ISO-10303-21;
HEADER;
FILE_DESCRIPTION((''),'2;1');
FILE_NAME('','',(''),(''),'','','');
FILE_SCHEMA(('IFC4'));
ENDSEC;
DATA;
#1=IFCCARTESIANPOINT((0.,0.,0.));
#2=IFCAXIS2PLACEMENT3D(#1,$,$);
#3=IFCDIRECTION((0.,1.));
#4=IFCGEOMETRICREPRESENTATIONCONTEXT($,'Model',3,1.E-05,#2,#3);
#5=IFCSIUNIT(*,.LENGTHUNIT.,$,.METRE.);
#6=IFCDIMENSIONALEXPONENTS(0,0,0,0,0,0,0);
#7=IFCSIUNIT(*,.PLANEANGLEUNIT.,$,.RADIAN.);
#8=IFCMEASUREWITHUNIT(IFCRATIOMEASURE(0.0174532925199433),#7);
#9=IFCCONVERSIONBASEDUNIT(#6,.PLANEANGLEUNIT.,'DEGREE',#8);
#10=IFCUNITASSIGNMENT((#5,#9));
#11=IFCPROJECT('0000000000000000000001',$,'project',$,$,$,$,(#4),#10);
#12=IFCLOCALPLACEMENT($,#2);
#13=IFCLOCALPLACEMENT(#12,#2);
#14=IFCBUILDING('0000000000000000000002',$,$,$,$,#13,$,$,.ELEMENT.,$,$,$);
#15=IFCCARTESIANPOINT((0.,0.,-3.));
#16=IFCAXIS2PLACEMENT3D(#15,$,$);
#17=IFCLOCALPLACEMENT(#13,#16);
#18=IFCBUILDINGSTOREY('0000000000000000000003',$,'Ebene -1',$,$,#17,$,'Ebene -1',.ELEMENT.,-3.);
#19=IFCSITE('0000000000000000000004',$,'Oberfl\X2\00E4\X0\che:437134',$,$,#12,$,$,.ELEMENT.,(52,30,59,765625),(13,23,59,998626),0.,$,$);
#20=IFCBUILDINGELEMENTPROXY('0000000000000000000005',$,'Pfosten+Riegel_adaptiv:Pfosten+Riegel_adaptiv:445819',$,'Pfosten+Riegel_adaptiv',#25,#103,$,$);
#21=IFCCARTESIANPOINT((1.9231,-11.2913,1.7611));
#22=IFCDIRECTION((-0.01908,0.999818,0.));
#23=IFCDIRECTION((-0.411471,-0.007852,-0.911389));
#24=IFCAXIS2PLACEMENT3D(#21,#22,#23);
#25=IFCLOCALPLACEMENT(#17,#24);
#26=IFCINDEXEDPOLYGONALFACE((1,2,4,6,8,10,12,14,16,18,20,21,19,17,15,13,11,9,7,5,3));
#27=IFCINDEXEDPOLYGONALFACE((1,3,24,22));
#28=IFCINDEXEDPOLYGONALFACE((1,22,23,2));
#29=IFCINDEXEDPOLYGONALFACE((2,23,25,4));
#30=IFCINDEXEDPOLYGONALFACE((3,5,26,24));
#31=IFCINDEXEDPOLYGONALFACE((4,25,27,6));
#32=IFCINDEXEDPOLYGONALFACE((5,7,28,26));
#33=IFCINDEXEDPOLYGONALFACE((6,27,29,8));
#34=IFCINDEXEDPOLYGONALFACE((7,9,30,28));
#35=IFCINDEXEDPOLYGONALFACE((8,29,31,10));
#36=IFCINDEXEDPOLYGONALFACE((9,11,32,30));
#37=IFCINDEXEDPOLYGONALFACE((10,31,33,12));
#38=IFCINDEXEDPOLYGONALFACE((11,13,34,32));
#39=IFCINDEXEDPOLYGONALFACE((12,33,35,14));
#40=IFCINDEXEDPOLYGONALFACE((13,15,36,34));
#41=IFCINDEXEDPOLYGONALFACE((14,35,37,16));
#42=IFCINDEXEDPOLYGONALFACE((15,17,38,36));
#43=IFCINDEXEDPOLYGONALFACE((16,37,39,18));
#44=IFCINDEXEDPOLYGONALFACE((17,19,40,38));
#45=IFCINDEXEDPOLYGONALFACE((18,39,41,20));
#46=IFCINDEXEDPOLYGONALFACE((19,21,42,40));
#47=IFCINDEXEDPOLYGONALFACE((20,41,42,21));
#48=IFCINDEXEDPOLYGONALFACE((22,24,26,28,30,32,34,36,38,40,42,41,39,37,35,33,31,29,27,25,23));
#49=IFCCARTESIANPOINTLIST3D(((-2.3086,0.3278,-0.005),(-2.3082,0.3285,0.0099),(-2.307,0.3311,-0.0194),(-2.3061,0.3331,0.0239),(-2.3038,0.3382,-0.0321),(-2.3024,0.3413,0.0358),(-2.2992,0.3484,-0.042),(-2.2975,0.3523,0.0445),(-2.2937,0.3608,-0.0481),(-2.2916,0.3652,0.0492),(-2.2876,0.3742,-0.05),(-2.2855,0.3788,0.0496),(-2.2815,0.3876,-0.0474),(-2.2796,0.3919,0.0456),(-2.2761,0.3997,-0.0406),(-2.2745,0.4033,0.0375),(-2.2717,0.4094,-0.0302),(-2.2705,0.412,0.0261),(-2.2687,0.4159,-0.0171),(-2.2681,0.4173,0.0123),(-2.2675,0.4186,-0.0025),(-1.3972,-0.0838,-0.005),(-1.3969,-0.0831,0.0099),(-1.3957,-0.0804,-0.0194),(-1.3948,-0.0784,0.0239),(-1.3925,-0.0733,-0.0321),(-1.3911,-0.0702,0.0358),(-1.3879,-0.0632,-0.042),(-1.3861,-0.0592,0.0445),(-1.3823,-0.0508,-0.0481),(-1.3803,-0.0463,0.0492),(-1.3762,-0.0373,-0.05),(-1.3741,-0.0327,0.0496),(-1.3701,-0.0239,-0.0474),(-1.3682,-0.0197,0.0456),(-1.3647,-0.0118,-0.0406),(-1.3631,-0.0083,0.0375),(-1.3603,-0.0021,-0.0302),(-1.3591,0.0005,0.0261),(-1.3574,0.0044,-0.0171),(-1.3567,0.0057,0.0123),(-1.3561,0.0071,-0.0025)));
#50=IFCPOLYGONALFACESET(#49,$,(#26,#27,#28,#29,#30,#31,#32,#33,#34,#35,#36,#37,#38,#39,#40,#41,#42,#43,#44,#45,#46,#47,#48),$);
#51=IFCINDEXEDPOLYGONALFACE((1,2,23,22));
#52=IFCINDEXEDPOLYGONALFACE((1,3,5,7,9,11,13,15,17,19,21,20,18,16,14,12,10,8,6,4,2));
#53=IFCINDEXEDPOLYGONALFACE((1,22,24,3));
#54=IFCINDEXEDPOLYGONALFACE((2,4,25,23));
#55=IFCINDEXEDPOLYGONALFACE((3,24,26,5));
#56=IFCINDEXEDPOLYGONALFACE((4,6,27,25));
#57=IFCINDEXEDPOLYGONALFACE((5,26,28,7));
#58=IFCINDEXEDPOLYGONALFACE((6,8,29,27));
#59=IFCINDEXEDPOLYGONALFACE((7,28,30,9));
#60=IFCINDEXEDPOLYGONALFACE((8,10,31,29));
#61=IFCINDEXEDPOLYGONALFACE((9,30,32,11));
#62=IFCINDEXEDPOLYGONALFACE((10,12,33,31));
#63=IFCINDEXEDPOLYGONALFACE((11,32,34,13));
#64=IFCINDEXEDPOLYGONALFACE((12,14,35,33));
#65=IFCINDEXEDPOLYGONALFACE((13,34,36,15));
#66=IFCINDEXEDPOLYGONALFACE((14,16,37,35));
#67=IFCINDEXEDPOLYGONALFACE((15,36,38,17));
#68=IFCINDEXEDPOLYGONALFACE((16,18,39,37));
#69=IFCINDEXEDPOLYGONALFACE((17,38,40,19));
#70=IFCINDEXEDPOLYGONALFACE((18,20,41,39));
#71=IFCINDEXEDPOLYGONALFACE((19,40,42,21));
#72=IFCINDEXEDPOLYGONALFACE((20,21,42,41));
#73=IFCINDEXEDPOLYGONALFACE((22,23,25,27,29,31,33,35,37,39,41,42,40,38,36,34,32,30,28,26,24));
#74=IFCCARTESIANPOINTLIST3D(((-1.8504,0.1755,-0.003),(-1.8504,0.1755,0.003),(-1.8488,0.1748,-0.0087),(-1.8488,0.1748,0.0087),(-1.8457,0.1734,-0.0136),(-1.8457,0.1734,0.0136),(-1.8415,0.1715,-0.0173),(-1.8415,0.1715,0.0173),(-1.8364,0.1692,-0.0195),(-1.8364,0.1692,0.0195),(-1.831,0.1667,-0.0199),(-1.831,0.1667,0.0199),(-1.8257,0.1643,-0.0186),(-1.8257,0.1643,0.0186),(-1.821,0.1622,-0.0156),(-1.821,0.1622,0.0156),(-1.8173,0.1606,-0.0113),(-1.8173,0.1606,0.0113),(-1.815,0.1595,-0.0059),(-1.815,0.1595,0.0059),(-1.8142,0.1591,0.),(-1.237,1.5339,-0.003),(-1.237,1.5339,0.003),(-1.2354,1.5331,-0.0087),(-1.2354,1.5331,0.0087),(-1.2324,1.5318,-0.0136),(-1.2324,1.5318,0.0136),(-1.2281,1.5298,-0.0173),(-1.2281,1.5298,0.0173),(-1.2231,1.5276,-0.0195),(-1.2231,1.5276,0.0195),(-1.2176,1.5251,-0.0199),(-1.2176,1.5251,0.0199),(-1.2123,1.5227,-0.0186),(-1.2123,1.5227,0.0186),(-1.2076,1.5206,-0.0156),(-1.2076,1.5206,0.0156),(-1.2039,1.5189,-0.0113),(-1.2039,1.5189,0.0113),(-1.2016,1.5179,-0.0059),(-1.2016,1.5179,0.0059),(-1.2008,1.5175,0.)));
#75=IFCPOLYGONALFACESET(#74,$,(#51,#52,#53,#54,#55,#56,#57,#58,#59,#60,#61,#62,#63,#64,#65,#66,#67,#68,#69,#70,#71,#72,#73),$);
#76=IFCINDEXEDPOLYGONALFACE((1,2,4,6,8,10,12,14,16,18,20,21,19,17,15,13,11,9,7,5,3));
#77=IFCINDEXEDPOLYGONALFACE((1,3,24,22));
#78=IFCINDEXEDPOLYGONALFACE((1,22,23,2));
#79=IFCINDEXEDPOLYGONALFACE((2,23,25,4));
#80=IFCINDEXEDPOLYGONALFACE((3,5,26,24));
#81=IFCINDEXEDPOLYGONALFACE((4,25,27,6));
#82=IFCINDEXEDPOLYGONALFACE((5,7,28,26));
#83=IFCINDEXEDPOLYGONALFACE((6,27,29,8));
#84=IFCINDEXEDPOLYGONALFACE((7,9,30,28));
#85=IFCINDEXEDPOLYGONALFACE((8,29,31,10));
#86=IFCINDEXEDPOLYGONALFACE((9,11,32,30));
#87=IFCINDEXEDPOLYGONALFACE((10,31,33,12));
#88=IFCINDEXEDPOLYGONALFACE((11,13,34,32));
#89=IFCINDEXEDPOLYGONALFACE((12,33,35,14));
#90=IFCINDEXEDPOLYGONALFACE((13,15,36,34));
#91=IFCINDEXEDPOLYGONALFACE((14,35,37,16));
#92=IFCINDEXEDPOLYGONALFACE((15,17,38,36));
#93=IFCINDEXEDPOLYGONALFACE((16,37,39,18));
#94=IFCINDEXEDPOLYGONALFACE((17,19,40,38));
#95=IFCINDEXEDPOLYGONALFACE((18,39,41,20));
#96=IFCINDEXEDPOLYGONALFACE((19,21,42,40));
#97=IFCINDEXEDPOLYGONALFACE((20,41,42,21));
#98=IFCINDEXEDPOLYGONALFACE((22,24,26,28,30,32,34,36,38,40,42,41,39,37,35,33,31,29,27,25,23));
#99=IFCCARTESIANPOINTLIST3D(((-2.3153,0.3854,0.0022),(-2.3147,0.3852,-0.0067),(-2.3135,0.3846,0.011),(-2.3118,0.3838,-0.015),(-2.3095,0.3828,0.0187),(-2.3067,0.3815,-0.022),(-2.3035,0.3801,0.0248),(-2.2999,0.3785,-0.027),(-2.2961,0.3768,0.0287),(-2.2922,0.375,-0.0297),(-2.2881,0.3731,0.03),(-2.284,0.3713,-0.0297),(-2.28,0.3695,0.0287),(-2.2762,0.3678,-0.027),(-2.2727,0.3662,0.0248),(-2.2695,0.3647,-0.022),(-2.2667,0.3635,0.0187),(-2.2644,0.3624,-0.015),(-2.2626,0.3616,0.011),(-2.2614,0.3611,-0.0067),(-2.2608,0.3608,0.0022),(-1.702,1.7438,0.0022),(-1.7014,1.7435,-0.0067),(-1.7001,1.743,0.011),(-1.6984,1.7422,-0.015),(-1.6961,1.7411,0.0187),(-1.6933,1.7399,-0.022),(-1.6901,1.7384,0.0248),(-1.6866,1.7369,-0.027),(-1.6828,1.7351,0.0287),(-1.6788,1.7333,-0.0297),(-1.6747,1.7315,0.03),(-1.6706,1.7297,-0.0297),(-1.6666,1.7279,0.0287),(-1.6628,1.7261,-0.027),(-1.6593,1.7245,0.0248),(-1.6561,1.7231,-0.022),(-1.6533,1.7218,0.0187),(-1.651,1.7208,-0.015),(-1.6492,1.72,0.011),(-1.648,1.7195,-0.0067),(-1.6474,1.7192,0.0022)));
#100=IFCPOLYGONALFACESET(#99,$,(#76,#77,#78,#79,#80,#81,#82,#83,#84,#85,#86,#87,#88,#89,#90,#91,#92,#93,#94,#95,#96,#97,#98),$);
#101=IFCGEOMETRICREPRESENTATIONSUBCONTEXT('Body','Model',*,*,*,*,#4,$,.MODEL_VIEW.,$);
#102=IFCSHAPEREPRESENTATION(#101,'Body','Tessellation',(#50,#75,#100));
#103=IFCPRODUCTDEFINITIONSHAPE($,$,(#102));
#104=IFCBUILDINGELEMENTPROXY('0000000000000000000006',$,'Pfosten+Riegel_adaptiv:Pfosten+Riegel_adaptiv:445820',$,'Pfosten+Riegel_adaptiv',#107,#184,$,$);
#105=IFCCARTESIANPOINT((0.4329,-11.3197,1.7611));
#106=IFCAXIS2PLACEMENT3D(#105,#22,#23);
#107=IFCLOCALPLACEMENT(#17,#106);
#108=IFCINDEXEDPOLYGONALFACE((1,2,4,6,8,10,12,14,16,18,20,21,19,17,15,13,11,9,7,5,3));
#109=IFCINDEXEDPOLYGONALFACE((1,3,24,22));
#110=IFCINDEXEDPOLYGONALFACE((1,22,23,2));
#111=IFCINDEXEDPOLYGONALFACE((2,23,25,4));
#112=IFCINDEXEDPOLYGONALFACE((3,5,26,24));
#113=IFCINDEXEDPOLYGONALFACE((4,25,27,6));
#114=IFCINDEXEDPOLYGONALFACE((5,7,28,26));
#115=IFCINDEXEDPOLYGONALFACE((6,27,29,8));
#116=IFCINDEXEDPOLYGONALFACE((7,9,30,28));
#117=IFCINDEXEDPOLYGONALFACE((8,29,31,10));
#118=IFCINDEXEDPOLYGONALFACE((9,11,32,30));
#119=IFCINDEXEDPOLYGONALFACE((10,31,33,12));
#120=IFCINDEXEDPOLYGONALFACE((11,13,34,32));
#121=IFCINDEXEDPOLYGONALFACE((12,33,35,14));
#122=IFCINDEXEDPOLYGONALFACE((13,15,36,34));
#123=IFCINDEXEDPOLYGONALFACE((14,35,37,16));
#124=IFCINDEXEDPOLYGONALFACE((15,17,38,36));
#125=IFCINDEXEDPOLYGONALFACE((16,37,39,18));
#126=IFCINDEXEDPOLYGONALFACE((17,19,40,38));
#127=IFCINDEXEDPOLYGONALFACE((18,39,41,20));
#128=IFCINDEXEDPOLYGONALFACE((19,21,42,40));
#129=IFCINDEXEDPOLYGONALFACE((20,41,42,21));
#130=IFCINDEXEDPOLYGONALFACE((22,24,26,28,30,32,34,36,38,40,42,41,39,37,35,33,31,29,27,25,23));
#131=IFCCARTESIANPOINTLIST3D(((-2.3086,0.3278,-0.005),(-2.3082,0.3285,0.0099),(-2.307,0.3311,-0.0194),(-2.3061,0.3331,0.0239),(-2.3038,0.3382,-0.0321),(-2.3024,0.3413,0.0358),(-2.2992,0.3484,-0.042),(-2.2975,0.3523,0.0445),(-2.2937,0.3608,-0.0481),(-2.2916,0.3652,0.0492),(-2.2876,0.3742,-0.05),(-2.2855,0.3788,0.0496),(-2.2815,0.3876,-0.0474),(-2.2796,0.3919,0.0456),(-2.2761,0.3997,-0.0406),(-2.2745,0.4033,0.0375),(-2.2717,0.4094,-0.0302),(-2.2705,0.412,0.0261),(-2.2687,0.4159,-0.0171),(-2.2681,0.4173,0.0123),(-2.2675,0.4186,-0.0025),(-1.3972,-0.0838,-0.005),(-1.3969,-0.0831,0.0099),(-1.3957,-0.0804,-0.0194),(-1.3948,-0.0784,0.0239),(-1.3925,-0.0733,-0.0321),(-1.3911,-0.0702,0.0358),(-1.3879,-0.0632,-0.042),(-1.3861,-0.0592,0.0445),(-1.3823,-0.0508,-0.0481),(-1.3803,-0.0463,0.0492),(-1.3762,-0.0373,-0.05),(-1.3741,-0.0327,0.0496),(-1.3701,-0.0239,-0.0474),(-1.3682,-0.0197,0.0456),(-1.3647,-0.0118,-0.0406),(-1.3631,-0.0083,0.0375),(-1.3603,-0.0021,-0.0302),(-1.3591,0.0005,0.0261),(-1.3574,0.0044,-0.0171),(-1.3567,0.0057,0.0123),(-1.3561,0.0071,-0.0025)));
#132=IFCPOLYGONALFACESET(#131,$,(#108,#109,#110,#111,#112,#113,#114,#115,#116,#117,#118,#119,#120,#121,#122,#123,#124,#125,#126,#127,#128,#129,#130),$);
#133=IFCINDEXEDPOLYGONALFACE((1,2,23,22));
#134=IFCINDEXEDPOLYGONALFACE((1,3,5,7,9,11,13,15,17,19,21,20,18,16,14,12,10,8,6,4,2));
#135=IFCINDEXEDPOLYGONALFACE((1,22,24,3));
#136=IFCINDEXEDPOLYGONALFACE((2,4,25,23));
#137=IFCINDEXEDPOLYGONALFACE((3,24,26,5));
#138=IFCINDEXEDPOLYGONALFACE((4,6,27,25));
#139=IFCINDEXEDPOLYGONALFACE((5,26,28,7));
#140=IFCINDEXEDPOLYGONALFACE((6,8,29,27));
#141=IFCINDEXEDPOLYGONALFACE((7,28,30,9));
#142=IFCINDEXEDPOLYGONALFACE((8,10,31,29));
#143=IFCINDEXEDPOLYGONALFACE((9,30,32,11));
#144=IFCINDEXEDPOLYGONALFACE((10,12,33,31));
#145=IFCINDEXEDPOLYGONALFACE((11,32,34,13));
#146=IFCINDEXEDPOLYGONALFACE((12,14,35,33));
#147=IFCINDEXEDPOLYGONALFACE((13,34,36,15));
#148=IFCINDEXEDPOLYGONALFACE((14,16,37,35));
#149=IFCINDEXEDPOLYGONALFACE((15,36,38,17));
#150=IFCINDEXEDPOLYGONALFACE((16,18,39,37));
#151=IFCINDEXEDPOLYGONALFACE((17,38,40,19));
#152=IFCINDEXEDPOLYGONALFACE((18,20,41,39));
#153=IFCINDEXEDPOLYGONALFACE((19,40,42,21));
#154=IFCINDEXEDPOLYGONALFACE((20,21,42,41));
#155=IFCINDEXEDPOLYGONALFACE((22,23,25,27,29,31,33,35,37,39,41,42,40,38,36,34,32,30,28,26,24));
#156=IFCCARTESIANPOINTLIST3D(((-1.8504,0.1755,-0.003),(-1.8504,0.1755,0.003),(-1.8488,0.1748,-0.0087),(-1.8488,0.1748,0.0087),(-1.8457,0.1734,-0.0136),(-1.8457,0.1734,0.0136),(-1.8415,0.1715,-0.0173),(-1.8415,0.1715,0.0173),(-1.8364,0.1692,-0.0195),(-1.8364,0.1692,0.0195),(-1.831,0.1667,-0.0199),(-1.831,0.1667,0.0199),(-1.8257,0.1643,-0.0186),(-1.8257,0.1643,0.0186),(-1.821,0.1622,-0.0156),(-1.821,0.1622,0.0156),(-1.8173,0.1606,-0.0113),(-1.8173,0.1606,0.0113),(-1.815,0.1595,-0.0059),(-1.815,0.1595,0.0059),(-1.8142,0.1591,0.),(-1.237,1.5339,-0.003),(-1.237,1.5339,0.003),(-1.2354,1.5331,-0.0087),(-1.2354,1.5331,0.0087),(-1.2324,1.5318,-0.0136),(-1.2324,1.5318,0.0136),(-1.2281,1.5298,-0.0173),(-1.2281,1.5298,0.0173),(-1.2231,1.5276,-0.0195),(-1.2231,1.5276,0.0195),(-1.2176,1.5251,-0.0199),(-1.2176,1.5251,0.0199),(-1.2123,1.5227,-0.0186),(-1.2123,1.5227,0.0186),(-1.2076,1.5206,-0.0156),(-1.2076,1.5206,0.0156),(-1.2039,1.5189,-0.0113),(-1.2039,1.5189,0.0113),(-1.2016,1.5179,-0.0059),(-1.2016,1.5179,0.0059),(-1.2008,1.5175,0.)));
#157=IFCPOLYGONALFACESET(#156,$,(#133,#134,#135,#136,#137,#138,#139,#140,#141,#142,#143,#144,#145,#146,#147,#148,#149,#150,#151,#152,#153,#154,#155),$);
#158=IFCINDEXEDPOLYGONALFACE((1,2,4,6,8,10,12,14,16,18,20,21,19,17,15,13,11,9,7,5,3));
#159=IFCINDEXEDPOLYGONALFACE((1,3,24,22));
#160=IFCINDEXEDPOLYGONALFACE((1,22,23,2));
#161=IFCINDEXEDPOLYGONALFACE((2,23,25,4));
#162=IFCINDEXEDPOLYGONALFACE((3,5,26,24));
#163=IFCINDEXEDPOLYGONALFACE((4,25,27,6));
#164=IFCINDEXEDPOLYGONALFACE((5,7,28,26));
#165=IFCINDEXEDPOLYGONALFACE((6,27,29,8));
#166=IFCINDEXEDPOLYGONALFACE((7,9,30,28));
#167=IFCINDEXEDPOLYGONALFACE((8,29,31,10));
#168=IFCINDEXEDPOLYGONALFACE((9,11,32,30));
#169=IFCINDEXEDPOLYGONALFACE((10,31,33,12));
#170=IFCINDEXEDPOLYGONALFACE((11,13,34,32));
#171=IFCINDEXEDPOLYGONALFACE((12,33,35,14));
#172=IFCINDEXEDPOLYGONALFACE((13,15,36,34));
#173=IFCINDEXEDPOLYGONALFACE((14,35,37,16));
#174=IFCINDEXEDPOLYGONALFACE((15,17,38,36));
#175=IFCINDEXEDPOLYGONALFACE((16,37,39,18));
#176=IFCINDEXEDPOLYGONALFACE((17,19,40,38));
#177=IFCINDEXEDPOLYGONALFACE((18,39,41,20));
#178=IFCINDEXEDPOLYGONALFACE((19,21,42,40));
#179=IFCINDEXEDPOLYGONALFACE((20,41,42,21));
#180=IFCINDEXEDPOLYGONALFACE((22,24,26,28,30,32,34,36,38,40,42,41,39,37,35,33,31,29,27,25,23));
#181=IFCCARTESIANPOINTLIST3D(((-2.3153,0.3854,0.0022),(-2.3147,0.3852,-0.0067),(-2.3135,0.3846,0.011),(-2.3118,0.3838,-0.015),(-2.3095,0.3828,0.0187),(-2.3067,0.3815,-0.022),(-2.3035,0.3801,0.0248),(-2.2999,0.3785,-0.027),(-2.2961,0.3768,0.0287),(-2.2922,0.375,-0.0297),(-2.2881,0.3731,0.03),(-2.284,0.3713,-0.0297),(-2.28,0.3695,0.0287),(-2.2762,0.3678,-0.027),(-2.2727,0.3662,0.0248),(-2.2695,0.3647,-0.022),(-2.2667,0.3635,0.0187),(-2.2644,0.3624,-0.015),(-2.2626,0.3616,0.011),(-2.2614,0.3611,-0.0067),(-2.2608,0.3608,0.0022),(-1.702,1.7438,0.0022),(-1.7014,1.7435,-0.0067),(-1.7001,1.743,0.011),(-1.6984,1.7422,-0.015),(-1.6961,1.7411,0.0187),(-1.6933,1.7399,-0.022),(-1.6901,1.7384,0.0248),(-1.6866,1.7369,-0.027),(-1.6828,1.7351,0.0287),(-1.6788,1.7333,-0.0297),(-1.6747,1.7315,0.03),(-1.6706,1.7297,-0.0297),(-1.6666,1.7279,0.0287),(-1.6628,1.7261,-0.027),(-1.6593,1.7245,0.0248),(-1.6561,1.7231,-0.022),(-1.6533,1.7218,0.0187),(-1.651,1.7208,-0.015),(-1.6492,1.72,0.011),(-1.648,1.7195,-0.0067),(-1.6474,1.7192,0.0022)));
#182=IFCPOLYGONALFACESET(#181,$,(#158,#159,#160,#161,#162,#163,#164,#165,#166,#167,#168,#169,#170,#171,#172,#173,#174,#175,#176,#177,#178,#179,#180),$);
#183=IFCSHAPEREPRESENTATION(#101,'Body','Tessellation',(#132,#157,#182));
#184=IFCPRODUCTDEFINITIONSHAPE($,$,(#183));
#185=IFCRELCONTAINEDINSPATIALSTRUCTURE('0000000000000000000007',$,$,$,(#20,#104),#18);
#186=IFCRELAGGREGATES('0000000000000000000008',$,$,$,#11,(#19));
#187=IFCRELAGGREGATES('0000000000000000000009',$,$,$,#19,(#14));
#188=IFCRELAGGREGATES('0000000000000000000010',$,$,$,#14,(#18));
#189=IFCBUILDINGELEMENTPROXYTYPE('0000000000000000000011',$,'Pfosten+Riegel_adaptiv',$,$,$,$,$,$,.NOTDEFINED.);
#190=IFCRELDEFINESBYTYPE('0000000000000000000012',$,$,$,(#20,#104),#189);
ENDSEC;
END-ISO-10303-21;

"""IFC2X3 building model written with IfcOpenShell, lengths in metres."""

from ifc_helpers import new_model, entity, si_unit, converted_unit, direction, frame, frame_2d, origin, place, context, subcontext, project, spatial, circle, extrude, source, transform, mapped, type_object, type_shapes, element, save


model = new_model("IFC2X3")

# Units and contexts
model_context = context("Model", 3, precision=1e-05, world=origin(), true_north=direction((0.0, 1.0)))
body_context = subcontext(model_context, "Body", "Model", "MODEL_VIEW")
ifc_project = project(units=[si_unit("LENGTHUNIT", "METRE"), converted_unit("PLANEANGLEUNIT", "DEGREE", entity("IfcRatioMeasure", 0.0174532925199433), si_unit("PLANEANGLEUNIT", "RADIAN"), dimensions=[0, 0, 0, 0, 0, 0, 0])], contexts=[model_context])

# Site, building, storey
site_placement = place(None, origin())
site = spatial("IfcSite", under=ifc_project, at=site_placement, Name="Oberfläche:437134", CompositionType="ELEMENT", RefLatitude=(52, 30, 59, 765625), RefLongitude=(13, 23, 59, 998626), RefElevation=0.0)
building_placement = place(site_placement, origin())
building = spatial("IfcBuilding", under=site, at=building_placement, CompositionType="ELEMENT")
storey_placement = place(building_placement, frame((0.0, 0.0, -3.0)))
storey = spatial("IfcBuildingStorey", under=building, at=storey_placement, Name="Ebene -1", LongName="Ebene -1", CompositionType="ELEMENT", Elevation=-3.0)

# Building element proxies
building_element_proxy_type_1 = type_object("IfcBuildingElementProxyType", Name="Pfosten+Riegel_adaptiv", PredefinedType="NOTDEFINED")
shared_shape_1 = source(origin(), body_context, "Body", "SweptSolid", [
    extrude(circle(Radius=0.05, at=frame_2d((0.0, 0.0), x_axis=(1.0, 0.0))), frame((-2.2881, 0.3731, 0.0), z_axis=(0.911389, -0.411546, 0.0), x_axis=(0.16937, 0.375078, 0.911389)), (0.0, 0.0, 1.0), 1.0),
    extrude(circle(Radius=0.02, at=frame_2d((0.0, 0.0), x_axis=(1.0, 0.0))), frame((-1.8324, 0.1674, 0.0), z_axis=(0.411546, 0.911389, 0.0), x_axis=(0.911389, -0.411546, 0.0)), (0.0, 0.0, 1.0), 1.4904),
    extrude(circle(Radius=0.03, at=frame_2d((0.0, 0.0), x_axis=(1.0, 0.0))), frame((-2.2881, 0.3731, 0.0), z_axis=(0.411546, 0.911389, 0.0), x_axis=(0.0, 0.0, 1.0)), (0.0, 0.0, 1.0), 1.4904),
])
type_shapes(building_element_proxy_type_1, [shared_shape_1])
for number, where, z_axis, x_axis, name in (
    (1, (1.9231, -11.2913, 1.7611), (-0.01908, 0.999818, 0.0), (-0.411471, -0.007852, -0.911389), "Pfosten+Riegel_adaptiv:Pfosten+Riegel_adaptiv:445819"),
    (2, (0.4329, -11.3197, 1.7611), (-0.01908, 0.999818, 0.0), (-0.411471, -0.007852, -0.911389), "Pfosten+Riegel_adaptiv:Pfosten+Riegel_adaptiv:445820"),
):
    element("IfcBuildingElementProxy", number, at=place(storey_placement, frame(where, z_axis=z_axis, x_axis=x_axis)), inside=storey, type_object=building_element_proxy_type_1, Name=name, ObjectType="Pfosten+Riegel_adaptiv", context=body_context, shape_type="MappedRepresentation", body=[
        mapped(shared_shape_1, transform((0.0, 0.0, 0.0), scale=1.0)),
    ])

save(model, "model.ifc")
